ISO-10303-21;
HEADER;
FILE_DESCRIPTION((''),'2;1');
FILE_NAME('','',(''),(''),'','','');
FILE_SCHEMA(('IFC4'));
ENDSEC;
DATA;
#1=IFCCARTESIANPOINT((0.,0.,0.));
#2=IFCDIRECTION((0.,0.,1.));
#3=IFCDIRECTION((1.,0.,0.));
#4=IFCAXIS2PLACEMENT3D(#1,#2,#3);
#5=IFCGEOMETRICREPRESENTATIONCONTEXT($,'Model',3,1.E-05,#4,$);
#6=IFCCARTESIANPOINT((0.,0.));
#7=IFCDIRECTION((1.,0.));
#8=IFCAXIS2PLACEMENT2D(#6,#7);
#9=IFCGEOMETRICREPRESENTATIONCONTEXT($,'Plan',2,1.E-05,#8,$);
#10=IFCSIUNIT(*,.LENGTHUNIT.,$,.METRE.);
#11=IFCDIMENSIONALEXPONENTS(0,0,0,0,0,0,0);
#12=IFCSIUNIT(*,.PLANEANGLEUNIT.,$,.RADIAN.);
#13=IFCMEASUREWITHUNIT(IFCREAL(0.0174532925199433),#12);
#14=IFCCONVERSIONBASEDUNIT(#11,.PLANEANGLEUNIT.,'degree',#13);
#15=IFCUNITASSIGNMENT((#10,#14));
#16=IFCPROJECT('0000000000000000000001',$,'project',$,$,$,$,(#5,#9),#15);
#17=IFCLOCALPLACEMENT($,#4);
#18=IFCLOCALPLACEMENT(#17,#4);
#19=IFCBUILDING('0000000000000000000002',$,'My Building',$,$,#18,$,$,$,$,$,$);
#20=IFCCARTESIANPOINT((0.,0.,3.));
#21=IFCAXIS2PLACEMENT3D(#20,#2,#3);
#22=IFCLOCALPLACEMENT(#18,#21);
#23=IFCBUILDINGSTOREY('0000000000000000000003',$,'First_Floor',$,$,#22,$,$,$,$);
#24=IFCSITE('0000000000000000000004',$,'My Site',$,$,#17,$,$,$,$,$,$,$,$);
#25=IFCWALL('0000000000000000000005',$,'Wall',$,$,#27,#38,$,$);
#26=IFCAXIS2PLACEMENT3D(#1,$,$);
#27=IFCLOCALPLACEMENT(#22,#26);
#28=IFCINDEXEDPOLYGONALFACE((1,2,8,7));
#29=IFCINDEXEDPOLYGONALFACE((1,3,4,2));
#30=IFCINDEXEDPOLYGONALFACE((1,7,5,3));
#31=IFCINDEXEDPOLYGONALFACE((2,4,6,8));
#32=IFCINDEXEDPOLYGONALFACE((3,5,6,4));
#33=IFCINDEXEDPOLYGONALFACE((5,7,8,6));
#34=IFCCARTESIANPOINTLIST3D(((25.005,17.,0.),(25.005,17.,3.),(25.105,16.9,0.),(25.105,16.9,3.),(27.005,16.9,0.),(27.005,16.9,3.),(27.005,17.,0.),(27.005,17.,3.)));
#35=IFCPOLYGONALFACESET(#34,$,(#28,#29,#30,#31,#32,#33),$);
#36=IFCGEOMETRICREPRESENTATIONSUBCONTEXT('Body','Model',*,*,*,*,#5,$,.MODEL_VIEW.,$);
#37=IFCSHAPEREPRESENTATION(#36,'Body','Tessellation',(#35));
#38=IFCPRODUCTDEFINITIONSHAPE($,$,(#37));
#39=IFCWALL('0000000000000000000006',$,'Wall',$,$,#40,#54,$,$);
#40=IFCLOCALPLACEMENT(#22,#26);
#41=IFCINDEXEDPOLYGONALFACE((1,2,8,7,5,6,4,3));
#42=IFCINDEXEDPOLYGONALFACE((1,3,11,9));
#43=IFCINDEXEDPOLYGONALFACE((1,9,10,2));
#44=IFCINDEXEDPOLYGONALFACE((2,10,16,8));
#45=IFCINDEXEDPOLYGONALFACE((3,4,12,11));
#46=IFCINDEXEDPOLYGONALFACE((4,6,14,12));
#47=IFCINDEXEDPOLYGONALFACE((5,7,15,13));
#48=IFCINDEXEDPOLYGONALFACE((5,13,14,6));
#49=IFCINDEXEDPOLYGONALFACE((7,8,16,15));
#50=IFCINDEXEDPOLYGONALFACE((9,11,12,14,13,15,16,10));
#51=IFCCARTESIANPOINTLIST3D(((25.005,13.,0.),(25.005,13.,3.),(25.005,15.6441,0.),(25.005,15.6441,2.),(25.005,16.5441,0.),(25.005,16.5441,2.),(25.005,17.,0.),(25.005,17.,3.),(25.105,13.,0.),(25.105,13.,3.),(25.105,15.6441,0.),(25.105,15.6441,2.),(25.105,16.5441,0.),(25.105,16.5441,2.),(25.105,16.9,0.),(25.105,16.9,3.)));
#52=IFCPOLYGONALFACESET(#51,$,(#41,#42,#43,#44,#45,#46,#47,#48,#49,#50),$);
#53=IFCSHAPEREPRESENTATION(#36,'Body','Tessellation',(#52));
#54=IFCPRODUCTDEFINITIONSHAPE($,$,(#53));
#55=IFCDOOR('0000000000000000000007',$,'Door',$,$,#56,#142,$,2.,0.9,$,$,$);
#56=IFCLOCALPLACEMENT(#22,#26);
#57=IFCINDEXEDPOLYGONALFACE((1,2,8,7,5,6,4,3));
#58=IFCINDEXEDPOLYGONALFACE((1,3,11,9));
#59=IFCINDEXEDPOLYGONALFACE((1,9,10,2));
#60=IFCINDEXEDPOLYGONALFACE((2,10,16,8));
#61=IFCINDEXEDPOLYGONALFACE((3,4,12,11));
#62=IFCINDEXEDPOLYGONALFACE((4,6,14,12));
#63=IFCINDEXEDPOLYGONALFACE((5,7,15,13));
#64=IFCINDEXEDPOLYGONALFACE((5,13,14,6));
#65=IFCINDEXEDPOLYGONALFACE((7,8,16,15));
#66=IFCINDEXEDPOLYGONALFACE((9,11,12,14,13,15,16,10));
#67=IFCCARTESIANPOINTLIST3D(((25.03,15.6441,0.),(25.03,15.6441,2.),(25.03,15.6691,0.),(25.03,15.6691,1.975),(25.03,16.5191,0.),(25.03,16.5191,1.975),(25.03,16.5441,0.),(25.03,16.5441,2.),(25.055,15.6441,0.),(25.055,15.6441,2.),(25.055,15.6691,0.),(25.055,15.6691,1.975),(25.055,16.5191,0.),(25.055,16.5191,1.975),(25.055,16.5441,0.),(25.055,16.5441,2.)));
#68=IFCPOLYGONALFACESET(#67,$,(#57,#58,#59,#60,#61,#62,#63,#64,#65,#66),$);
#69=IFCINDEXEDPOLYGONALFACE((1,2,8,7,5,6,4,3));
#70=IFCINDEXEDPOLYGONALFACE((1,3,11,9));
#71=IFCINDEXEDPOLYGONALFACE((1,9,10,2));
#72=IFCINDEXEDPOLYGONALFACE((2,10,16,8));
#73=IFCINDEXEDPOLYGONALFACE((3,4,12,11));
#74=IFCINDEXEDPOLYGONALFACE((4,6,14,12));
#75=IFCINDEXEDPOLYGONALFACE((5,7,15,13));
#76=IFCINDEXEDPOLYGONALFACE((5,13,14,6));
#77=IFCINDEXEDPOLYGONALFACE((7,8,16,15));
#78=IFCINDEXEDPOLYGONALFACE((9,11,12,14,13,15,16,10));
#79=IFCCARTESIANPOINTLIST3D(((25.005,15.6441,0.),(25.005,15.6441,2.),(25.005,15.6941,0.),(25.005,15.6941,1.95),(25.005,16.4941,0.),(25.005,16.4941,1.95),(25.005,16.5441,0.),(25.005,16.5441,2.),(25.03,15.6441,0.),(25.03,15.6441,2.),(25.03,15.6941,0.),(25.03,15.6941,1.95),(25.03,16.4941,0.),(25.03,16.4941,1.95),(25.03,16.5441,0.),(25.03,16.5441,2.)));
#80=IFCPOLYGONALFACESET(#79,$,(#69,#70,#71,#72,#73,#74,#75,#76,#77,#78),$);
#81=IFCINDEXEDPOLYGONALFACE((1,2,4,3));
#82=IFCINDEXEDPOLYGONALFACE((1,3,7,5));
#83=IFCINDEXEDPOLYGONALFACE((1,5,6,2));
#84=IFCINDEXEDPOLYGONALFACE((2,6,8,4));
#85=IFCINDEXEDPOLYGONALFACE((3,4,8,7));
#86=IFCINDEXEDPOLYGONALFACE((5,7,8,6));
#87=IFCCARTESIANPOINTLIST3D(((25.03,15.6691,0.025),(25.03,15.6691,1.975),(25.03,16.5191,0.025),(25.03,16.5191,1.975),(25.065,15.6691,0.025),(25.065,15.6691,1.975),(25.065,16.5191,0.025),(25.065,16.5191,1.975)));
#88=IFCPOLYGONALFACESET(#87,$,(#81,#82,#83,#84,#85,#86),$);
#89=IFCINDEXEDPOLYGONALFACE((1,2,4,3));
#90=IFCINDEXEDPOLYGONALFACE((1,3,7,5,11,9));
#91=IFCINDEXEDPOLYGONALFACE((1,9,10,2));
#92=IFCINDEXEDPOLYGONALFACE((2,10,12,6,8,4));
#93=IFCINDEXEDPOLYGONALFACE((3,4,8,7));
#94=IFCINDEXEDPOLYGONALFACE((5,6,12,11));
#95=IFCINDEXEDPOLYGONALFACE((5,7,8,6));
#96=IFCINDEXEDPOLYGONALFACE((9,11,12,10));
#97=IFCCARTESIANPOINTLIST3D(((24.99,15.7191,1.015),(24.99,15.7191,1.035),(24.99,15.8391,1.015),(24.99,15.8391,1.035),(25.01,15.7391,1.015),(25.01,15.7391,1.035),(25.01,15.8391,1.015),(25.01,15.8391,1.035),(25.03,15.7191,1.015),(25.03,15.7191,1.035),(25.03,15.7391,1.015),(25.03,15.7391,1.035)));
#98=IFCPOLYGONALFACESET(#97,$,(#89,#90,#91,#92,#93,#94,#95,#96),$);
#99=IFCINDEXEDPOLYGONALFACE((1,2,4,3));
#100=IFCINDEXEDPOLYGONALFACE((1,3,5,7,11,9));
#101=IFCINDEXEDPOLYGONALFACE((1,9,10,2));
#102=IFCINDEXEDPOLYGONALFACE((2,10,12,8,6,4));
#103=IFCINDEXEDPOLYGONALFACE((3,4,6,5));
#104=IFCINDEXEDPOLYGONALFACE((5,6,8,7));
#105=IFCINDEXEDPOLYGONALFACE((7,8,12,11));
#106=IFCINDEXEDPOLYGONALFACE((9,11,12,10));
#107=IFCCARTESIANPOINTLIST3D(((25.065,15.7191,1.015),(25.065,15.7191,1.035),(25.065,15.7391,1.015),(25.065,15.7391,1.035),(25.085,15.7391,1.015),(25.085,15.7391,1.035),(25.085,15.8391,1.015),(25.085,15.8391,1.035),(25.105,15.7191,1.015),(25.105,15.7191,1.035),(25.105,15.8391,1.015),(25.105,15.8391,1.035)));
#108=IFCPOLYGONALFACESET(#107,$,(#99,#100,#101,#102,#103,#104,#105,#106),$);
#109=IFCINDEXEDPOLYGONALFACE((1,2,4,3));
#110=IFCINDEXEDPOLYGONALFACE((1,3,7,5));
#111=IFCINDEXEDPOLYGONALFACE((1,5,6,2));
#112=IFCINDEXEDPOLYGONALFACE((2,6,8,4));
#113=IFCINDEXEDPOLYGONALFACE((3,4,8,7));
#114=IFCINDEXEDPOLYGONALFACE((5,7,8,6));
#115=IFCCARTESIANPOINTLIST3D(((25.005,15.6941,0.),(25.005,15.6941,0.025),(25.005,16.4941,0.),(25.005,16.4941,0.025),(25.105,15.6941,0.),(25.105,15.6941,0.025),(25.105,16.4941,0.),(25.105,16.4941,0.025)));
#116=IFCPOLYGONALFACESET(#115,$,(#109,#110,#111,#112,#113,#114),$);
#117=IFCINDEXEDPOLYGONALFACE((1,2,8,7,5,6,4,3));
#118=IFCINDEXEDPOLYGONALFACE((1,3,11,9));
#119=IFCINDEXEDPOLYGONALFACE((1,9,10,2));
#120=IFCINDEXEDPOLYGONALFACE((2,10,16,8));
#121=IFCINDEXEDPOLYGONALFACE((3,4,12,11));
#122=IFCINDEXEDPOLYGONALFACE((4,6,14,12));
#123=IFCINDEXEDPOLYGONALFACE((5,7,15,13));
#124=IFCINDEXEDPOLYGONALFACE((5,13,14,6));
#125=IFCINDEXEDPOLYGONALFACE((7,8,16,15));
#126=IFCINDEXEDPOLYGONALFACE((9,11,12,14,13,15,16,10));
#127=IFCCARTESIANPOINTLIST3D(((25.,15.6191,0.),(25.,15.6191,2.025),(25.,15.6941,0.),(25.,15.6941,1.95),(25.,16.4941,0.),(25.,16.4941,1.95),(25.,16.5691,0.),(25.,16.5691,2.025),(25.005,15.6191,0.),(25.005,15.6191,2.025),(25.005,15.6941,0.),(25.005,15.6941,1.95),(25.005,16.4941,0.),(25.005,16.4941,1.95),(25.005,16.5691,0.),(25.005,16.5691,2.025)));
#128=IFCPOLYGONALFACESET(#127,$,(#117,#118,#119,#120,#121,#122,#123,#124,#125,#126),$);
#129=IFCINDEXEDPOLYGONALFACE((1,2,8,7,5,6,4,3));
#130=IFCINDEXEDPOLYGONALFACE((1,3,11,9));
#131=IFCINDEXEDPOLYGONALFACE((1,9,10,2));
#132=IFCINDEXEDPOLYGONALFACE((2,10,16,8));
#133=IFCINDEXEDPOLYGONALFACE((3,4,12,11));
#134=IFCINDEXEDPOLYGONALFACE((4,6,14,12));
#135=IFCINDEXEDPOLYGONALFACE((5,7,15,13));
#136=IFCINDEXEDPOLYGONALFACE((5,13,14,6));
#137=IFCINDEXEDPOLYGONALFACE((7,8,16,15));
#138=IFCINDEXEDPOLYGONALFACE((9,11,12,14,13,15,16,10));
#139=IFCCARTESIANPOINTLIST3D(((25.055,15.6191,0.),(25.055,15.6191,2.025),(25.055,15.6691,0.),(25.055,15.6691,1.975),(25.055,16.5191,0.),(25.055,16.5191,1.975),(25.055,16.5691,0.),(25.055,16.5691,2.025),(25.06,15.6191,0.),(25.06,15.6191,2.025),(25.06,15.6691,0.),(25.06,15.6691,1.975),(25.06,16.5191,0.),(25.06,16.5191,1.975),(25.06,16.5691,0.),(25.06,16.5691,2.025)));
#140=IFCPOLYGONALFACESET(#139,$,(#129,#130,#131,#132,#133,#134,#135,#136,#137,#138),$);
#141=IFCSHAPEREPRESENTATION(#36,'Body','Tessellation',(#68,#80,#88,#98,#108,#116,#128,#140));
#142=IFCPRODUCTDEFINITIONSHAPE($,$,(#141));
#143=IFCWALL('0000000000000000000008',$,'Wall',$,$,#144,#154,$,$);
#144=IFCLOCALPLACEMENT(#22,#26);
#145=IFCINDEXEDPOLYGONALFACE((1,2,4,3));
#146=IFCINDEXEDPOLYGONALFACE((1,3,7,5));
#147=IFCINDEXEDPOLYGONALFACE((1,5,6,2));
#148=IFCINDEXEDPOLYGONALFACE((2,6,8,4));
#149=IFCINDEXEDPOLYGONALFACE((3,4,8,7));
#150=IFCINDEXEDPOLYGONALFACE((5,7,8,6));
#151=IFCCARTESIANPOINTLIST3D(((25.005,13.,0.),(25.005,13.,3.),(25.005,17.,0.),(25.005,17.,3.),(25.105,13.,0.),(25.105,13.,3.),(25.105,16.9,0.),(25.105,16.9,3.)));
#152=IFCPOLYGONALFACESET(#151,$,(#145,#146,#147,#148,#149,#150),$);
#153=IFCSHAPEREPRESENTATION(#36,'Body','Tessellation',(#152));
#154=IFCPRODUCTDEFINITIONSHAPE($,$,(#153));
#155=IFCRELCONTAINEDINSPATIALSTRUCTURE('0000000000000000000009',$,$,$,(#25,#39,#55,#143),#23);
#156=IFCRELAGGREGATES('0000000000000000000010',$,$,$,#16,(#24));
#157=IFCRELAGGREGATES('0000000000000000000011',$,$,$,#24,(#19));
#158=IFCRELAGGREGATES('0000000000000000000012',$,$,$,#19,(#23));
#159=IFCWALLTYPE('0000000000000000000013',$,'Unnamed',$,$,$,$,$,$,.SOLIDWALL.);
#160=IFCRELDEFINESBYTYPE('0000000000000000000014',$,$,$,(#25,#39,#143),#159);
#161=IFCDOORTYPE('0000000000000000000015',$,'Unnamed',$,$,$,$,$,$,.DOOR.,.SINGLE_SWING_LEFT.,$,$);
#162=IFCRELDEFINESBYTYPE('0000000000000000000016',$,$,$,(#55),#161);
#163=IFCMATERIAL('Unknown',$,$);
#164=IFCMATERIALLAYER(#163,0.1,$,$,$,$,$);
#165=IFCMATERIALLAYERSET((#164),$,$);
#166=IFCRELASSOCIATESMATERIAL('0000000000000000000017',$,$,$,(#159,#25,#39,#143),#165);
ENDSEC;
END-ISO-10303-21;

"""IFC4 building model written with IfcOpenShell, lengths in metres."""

from ifc_helpers import new_model, entity, si_unit, converted_unit, frame, origin_with_axes, origin_2d_with_axis, place, context, subcontext, project, spatial, line, indexed_curve, outline, extrude, shape, source, transform, mapped, material, layer, layer_set, layer_usage, type_object, type_shapes, element, fill, save


model = new_model("IFC4")

# Units and contexts
model_context = context("Model", 3, precision=1e-05, world=origin_with_axes())
plan_context = context("Plan", 2, precision=1e-05, world=origin_2d_with_axis())
body_context_1 = subcontext(model_context, "Body", "Model", "MODEL_VIEW")
body_context_2 = subcontext(plan_context, "Body", "Plan", "PLAN_VIEW")
ifc_project = project(units=[si_unit("LENGTHUNIT", "METRE"), converted_unit("PLANEANGLEUNIT", "degree", entity("IfcReal", 0.0174532925199433), si_unit("PLANEANGLEUNIT", "RADIAN"), dimensions=[0, 0, 0, 0, 0, 0, 0])], contexts=[model_context, plan_context])

# Site, building, storey
site_placement = place(None, origin_with_axes())
site = spatial("IfcSite", under=ifc_project, at=site_placement, Name="My Site")
building_placement = place(site_placement, origin_with_axes())
building = spatial("IfcBuilding", under=site, at=building_placement, Name="My Building")
storey_placement = place(building_placement, frame((0.0, 0.0, 3.0), z_axis=(0.0, 0.0, 1.0), x_axis=(1.0, 0.0, 0.0)))
storey = spatial("IfcBuildingStorey", under=building, at=storey_placement, Name="First_Floor")

# Wall
ifc_material = material(Name="Unknown")
ifc_layer = layer(ifc_material, 0.1)
ifc_layer_set = layer_set([ifc_layer])
ifc_layer_usage_1 = layer_usage(ifc_layer_set, "AXIS2", "POSITIVE", 0.0)
wall_type = type_object("IfcWallType", Name="Unnamed", PredefinedType="SOLIDWALL", material=ifc_layer_set)
wall_1_placement = place(storey_placement, frame((27.005, 17.0, 0.0), z_axis=(0.0, 0.0, 1.0), x_axis=(-1.0, 0.0, 0.0)))
element("IfcWall", 1, at=wall_1_placement, inside=storey, type_object=wall_type, material=ifc_layer_usage_1, Name="Wall", context=body_context_1, shape_type="SweptSolid", body=[
    extrude(outline(indexed_curve([(0.0, 0.0), (0.0, 0.1), (1.9, 0.1), (2.0, 0.0)], segments=[line(1, 2, 3, 4, 1)])), origin_with_axes(), (0.0, 0.0, 1.0), 3.0),
])

# Wall, opening, door
ifc_layer_usage_2 = layer_usage(ifc_layer_set, "AXIS2", "POSITIVE", 0.0)
wall_2_placement = place(storey_placement, frame((25.005, 17.0, 0.0), z_axis=(0.0, 0.0, 1.0), x_axis=(0.0, -1.0, 0.0)))
wall_2 = element("IfcWall", 2, at=wall_2_placement, inside=storey, type_object=wall_type, material=ifc_layer_usage_2, Name="Wall", context=body_context_1, shape_type="SweptSolid", body=[
    extrude(outline(indexed_curve([(0.0, 0.0), (0.1, 0.1), (4.0, 0.1), (4.0, 0.0)], segments=[line(1, 2, 3, 4, 1)])), origin_with_axes(), (0.0, 0.0, 1.0), 3.0),
])
shared_shape_1 = source(origin_with_axes(), body_context_1, "Body", "SweptSolid", [
    extrude(outline(indexed_curve([(0.0, 0.0), (0.9, 0.0), (0.9, 2.0), (0.0, 2.0)], segments=[line(1, 2, 3, 4, 1)])), frame((0.0, -0.6, 0.0), z_axis=(0.0, -1.0, 0.0), x_axis=(1.0, 0.0, 0.0)), (0.0, 0.0, -1.0), 1.2),
])
opening_1_placement = place(wall_2_placement, frame((0.4559, 0.0, 0.0), z_axis=(0.0, 0.0, 1.0), x_axis=(1.0, 0.0, 0.0)))
opening_1 = element("IfcOpeningElement", 3, at=opening_1_placement, cuts=wall_2, PredefinedType="OPENING", context=body_context_1, shape_type="MappedRepresentation", body=[
    mapped(shared_shape_1, transform((0.0, 0.0, 0.0), x_axis=(1.0, 0.0, 0.0), y_axis=(0.0, 1.0, 0.0), z_axis=(0.0, 0.0, 1.0), scale=1.0)),
])
door_type = type_object("IfcDoorType", Name="Unnamed", OperationType="SINGLE_SWING_LEFT", PredefinedType="DOOR")
shared_shape_2 = source(origin_with_axes(), body_context_1, "Body", "SweptSolid", [
    extrude(outline(indexed_curve([(0.0, 0.0), (0.0, 2.0), (0.9, 2.0), (0.9, 0.0), (0.875, 0.0), (0.875, 1.975), (0.025, 1.975), (0.025, 0.0)], segments=[line(1, 2, 3, 4, 5, 6, 7, 8, 1)])), frame((0.0, 0.025, 0.0), z_axis=(0.0, -1.0, 0.0), x_axis=(1.0, 0.0, 0.0)), (0.0, 0.0, -1.0), 0.025),
    extrude(outline(indexed_curve([(0.0, 0.0), (0.0, 2.0), (0.9, 2.0), (0.9, 0.0), (0.85, 0.0), (0.85, 1.95), (0.05, 1.95), (0.05, 0.0)], segments=[line(1, 2, 3, 4, 5, 6, 7, 8, 1)])), frame((0.0, 0.0, 0.0), z_axis=(0.0, -1.0, 0.0), x_axis=(1.0, 0.0, 0.0)), (0.0, 0.0, -1.0), 0.025),
    extrude(outline(indexed_curve([(0.0, 0.0), (0.85, 0.0), (0.85, 0.035), (0.0, 0.035)], segments=[line(1, 2, 3, 4, 1)])), frame((0.025, 0.025, 0.025), z_axis=(0.0, 0.0, 1.0), x_axis=(1.0, 0.0, 0.0)), (0.0, 0.0, 1.0), 1.95),
    extrude(outline(indexed_curve([(0.0, 0.0), (0.0, -0.04), (-0.12, -0.04), (-0.12, -0.02), (-0.02, -0.02), (-0.02, 0.0)], segments=[line(1, 2, 3, 4, 5, 6, 1)])), frame((0.825, 0.025, 1.015), z_axis=(0.0, 0.0, 1.0), x_axis=(1.0, 0.0, 0.0)), (0.0, 0.0, 1.0), 0.02),
    extrude(outline(indexed_curve([(0.0, 0.0), (0.0, 0.04), (-0.12, 0.04), (-0.12, 0.02), (-0.02, 0.02), (-0.02, 0.0)], segments=[line(1, 2, 3, 4, 5, 6, 1)])), frame((0.825, 0.06, 1.015), z_axis=(0.0, 0.0, 1.0), x_axis=(1.0, 0.0, 0.0)), (0.0, 0.0, 1.0), 0.02),
    extrude(outline(indexed_curve([(0.0, 0.0), (0.8, 0.0), (0.8, 0.1), (0.0, 0.1)], segments=[line(1, 2, 3, 4, 1)])), frame((0.05, 0.0, 0.0), z_axis=(0.0, 0.0, 1.0), x_axis=(1.0, 0.0, 0.0)), (0.0, 0.0, 1.0), 0.025),
    extrude(outline(indexed_curve([(0.0, 0.0), (0.0, 2.025), (0.95, 2.025), (0.95, 0.0), (0.875, 0.0), (0.875, 1.95), (0.075, 1.95), (0.075, 0.0)], segments=[line(1, 2, 3, 4, 5, 6, 7, 8, 1)])), frame((-0.025, -0.005, 0.0), z_axis=(0.0, -1.0, 0.0), x_axis=(1.0, 0.0, 0.0)), (0.0, 0.0, -1.0), 0.005),
    extrude(outline(indexed_curve([(0.0, 0.0), (0.0, 2.025), (0.95, 2.025), (0.95, 0.0), (0.9, 0.0), (0.9, 1.975), (0.05, 1.975), (0.05, 0.0)], segments=[line(1, 2, 3, 4, 5, 6, 7, 8, 1)])), frame((-0.025, 0.05, 0.0), z_axis=(0.0, -1.0, 0.0), x_axis=(1.0, 0.0, 0.0)), (0.0, 0.0, -1.0), 0.005),
])
shared_shape_3 = source(origin_with_axes(), body_context_2, "Body", "Curve2D", [
    entity("IfcIndexedPolyCurve", entity("IfcCartesianPointList2D", [[0.0, 0.0], [0.0, 0.05], [0.025, 0.05], [0.025, 0.025], [0.05, 0.025], [0.05, 0.0]]), [entity("IfcLineIndex", [1, 2, 3, 4, 5, 6, 1])]),
    entity("IfcIndexedPolyCurve", entity("IfcCartesianPointList2D", [[0.9, 0.0], [0.9, 0.05], [0.875, 0.05], [0.875, 0.025], [0.85, 0.025], [0.85, 0.0]]), [entity("IfcLineIndex", [1, 2, 3, 4, 5, 6, 1])]),
    entity("IfcTrimmedCurve", entity("IfcEllipse", entity("IfcAxis2Placement2D", entity("IfcCartesianPoint", [0.06, 0.05]), entity("IfcDirection", [1.0, 0.0])), 0.815, 0.85), [entity("IfcCartesianPoint", [0.875, 0.05])], [entity("IfcCartesianPoint", [0.06, 0.9])], True, "CARTESIAN"),
    entity("IfcIndexedPolyCurve", entity("IfcCartesianPointList2D", [[0.025, 0.05], [0.06, 0.05], [0.06, 0.9], [0.025, 0.9]]), [entity("IfcLineIndex", [1, 2, 3, 4, 1])]),
])
type_shapes(door_type, [shared_shape_2, shared_shape_3])
door_1_placement = place(opening_1_placement, frame((0.0, 0.0, 0.0), z_axis=(0.0, 0.0, 1.0), x_axis=(1.0, 0.0, 0.0)))
door_1 = element("IfcDoor", 4, at=door_1_placement, inside=storey, type_object=door_type, Name="Door", OverallHeight=2.0, OverallWidth=0.9, shapes=[
    shape(body_context_1, "Body", "MappedRepresentation", [mapped(shared_shape_2, transform((0.0, 0.0, 0.0), x_axis=(1.0, 0.0, 0.0), y_axis=(0.0, 1.0, 0.0), z_axis=(0.0, 0.0, 1.0), scale=1.0))]),
    shape(body_context_2, "Body", "MappedRepresentation", [mapped(shared_shape_3, transform((0.0, 0.0, 0.0), x_axis=(1.0, 0.0, 0.0), y_axis=(0.0, 1.0, 0.0), z_axis=(0.0, 0.0, 1.0), scale=1.0))]),
])
fill(opening_1, door_1)

# Wall
ifc_layer_usage_3 = layer_usage(ifc_layer_set, "AXIS2", "POSITIVE", 0.0)
wall_3_placement = place(storey_placement, frame((25.005, 17.0, 0.0), z_axis=(0.0, 0.0, 1.0), x_axis=(0.0, -1.0, 0.0)))
element("IfcWall", 5, at=wall_3_placement, inside=storey, type_object=wall_type, material=ifc_layer_usage_3, Name="Wall", context=body_context_1, shape_type="SweptSolid", body=[
    extrude(outline(indexed_curve([(0.0, 0.0), (0.1, 0.1), (4.0, 0.1), (4.0, 0.0)], segments=[line(1, 2, 3, 4, 1)])), origin_with_axes(), (0.0, 0.0, 1.0), 3.0),
])

save(model, "model.ifc")
